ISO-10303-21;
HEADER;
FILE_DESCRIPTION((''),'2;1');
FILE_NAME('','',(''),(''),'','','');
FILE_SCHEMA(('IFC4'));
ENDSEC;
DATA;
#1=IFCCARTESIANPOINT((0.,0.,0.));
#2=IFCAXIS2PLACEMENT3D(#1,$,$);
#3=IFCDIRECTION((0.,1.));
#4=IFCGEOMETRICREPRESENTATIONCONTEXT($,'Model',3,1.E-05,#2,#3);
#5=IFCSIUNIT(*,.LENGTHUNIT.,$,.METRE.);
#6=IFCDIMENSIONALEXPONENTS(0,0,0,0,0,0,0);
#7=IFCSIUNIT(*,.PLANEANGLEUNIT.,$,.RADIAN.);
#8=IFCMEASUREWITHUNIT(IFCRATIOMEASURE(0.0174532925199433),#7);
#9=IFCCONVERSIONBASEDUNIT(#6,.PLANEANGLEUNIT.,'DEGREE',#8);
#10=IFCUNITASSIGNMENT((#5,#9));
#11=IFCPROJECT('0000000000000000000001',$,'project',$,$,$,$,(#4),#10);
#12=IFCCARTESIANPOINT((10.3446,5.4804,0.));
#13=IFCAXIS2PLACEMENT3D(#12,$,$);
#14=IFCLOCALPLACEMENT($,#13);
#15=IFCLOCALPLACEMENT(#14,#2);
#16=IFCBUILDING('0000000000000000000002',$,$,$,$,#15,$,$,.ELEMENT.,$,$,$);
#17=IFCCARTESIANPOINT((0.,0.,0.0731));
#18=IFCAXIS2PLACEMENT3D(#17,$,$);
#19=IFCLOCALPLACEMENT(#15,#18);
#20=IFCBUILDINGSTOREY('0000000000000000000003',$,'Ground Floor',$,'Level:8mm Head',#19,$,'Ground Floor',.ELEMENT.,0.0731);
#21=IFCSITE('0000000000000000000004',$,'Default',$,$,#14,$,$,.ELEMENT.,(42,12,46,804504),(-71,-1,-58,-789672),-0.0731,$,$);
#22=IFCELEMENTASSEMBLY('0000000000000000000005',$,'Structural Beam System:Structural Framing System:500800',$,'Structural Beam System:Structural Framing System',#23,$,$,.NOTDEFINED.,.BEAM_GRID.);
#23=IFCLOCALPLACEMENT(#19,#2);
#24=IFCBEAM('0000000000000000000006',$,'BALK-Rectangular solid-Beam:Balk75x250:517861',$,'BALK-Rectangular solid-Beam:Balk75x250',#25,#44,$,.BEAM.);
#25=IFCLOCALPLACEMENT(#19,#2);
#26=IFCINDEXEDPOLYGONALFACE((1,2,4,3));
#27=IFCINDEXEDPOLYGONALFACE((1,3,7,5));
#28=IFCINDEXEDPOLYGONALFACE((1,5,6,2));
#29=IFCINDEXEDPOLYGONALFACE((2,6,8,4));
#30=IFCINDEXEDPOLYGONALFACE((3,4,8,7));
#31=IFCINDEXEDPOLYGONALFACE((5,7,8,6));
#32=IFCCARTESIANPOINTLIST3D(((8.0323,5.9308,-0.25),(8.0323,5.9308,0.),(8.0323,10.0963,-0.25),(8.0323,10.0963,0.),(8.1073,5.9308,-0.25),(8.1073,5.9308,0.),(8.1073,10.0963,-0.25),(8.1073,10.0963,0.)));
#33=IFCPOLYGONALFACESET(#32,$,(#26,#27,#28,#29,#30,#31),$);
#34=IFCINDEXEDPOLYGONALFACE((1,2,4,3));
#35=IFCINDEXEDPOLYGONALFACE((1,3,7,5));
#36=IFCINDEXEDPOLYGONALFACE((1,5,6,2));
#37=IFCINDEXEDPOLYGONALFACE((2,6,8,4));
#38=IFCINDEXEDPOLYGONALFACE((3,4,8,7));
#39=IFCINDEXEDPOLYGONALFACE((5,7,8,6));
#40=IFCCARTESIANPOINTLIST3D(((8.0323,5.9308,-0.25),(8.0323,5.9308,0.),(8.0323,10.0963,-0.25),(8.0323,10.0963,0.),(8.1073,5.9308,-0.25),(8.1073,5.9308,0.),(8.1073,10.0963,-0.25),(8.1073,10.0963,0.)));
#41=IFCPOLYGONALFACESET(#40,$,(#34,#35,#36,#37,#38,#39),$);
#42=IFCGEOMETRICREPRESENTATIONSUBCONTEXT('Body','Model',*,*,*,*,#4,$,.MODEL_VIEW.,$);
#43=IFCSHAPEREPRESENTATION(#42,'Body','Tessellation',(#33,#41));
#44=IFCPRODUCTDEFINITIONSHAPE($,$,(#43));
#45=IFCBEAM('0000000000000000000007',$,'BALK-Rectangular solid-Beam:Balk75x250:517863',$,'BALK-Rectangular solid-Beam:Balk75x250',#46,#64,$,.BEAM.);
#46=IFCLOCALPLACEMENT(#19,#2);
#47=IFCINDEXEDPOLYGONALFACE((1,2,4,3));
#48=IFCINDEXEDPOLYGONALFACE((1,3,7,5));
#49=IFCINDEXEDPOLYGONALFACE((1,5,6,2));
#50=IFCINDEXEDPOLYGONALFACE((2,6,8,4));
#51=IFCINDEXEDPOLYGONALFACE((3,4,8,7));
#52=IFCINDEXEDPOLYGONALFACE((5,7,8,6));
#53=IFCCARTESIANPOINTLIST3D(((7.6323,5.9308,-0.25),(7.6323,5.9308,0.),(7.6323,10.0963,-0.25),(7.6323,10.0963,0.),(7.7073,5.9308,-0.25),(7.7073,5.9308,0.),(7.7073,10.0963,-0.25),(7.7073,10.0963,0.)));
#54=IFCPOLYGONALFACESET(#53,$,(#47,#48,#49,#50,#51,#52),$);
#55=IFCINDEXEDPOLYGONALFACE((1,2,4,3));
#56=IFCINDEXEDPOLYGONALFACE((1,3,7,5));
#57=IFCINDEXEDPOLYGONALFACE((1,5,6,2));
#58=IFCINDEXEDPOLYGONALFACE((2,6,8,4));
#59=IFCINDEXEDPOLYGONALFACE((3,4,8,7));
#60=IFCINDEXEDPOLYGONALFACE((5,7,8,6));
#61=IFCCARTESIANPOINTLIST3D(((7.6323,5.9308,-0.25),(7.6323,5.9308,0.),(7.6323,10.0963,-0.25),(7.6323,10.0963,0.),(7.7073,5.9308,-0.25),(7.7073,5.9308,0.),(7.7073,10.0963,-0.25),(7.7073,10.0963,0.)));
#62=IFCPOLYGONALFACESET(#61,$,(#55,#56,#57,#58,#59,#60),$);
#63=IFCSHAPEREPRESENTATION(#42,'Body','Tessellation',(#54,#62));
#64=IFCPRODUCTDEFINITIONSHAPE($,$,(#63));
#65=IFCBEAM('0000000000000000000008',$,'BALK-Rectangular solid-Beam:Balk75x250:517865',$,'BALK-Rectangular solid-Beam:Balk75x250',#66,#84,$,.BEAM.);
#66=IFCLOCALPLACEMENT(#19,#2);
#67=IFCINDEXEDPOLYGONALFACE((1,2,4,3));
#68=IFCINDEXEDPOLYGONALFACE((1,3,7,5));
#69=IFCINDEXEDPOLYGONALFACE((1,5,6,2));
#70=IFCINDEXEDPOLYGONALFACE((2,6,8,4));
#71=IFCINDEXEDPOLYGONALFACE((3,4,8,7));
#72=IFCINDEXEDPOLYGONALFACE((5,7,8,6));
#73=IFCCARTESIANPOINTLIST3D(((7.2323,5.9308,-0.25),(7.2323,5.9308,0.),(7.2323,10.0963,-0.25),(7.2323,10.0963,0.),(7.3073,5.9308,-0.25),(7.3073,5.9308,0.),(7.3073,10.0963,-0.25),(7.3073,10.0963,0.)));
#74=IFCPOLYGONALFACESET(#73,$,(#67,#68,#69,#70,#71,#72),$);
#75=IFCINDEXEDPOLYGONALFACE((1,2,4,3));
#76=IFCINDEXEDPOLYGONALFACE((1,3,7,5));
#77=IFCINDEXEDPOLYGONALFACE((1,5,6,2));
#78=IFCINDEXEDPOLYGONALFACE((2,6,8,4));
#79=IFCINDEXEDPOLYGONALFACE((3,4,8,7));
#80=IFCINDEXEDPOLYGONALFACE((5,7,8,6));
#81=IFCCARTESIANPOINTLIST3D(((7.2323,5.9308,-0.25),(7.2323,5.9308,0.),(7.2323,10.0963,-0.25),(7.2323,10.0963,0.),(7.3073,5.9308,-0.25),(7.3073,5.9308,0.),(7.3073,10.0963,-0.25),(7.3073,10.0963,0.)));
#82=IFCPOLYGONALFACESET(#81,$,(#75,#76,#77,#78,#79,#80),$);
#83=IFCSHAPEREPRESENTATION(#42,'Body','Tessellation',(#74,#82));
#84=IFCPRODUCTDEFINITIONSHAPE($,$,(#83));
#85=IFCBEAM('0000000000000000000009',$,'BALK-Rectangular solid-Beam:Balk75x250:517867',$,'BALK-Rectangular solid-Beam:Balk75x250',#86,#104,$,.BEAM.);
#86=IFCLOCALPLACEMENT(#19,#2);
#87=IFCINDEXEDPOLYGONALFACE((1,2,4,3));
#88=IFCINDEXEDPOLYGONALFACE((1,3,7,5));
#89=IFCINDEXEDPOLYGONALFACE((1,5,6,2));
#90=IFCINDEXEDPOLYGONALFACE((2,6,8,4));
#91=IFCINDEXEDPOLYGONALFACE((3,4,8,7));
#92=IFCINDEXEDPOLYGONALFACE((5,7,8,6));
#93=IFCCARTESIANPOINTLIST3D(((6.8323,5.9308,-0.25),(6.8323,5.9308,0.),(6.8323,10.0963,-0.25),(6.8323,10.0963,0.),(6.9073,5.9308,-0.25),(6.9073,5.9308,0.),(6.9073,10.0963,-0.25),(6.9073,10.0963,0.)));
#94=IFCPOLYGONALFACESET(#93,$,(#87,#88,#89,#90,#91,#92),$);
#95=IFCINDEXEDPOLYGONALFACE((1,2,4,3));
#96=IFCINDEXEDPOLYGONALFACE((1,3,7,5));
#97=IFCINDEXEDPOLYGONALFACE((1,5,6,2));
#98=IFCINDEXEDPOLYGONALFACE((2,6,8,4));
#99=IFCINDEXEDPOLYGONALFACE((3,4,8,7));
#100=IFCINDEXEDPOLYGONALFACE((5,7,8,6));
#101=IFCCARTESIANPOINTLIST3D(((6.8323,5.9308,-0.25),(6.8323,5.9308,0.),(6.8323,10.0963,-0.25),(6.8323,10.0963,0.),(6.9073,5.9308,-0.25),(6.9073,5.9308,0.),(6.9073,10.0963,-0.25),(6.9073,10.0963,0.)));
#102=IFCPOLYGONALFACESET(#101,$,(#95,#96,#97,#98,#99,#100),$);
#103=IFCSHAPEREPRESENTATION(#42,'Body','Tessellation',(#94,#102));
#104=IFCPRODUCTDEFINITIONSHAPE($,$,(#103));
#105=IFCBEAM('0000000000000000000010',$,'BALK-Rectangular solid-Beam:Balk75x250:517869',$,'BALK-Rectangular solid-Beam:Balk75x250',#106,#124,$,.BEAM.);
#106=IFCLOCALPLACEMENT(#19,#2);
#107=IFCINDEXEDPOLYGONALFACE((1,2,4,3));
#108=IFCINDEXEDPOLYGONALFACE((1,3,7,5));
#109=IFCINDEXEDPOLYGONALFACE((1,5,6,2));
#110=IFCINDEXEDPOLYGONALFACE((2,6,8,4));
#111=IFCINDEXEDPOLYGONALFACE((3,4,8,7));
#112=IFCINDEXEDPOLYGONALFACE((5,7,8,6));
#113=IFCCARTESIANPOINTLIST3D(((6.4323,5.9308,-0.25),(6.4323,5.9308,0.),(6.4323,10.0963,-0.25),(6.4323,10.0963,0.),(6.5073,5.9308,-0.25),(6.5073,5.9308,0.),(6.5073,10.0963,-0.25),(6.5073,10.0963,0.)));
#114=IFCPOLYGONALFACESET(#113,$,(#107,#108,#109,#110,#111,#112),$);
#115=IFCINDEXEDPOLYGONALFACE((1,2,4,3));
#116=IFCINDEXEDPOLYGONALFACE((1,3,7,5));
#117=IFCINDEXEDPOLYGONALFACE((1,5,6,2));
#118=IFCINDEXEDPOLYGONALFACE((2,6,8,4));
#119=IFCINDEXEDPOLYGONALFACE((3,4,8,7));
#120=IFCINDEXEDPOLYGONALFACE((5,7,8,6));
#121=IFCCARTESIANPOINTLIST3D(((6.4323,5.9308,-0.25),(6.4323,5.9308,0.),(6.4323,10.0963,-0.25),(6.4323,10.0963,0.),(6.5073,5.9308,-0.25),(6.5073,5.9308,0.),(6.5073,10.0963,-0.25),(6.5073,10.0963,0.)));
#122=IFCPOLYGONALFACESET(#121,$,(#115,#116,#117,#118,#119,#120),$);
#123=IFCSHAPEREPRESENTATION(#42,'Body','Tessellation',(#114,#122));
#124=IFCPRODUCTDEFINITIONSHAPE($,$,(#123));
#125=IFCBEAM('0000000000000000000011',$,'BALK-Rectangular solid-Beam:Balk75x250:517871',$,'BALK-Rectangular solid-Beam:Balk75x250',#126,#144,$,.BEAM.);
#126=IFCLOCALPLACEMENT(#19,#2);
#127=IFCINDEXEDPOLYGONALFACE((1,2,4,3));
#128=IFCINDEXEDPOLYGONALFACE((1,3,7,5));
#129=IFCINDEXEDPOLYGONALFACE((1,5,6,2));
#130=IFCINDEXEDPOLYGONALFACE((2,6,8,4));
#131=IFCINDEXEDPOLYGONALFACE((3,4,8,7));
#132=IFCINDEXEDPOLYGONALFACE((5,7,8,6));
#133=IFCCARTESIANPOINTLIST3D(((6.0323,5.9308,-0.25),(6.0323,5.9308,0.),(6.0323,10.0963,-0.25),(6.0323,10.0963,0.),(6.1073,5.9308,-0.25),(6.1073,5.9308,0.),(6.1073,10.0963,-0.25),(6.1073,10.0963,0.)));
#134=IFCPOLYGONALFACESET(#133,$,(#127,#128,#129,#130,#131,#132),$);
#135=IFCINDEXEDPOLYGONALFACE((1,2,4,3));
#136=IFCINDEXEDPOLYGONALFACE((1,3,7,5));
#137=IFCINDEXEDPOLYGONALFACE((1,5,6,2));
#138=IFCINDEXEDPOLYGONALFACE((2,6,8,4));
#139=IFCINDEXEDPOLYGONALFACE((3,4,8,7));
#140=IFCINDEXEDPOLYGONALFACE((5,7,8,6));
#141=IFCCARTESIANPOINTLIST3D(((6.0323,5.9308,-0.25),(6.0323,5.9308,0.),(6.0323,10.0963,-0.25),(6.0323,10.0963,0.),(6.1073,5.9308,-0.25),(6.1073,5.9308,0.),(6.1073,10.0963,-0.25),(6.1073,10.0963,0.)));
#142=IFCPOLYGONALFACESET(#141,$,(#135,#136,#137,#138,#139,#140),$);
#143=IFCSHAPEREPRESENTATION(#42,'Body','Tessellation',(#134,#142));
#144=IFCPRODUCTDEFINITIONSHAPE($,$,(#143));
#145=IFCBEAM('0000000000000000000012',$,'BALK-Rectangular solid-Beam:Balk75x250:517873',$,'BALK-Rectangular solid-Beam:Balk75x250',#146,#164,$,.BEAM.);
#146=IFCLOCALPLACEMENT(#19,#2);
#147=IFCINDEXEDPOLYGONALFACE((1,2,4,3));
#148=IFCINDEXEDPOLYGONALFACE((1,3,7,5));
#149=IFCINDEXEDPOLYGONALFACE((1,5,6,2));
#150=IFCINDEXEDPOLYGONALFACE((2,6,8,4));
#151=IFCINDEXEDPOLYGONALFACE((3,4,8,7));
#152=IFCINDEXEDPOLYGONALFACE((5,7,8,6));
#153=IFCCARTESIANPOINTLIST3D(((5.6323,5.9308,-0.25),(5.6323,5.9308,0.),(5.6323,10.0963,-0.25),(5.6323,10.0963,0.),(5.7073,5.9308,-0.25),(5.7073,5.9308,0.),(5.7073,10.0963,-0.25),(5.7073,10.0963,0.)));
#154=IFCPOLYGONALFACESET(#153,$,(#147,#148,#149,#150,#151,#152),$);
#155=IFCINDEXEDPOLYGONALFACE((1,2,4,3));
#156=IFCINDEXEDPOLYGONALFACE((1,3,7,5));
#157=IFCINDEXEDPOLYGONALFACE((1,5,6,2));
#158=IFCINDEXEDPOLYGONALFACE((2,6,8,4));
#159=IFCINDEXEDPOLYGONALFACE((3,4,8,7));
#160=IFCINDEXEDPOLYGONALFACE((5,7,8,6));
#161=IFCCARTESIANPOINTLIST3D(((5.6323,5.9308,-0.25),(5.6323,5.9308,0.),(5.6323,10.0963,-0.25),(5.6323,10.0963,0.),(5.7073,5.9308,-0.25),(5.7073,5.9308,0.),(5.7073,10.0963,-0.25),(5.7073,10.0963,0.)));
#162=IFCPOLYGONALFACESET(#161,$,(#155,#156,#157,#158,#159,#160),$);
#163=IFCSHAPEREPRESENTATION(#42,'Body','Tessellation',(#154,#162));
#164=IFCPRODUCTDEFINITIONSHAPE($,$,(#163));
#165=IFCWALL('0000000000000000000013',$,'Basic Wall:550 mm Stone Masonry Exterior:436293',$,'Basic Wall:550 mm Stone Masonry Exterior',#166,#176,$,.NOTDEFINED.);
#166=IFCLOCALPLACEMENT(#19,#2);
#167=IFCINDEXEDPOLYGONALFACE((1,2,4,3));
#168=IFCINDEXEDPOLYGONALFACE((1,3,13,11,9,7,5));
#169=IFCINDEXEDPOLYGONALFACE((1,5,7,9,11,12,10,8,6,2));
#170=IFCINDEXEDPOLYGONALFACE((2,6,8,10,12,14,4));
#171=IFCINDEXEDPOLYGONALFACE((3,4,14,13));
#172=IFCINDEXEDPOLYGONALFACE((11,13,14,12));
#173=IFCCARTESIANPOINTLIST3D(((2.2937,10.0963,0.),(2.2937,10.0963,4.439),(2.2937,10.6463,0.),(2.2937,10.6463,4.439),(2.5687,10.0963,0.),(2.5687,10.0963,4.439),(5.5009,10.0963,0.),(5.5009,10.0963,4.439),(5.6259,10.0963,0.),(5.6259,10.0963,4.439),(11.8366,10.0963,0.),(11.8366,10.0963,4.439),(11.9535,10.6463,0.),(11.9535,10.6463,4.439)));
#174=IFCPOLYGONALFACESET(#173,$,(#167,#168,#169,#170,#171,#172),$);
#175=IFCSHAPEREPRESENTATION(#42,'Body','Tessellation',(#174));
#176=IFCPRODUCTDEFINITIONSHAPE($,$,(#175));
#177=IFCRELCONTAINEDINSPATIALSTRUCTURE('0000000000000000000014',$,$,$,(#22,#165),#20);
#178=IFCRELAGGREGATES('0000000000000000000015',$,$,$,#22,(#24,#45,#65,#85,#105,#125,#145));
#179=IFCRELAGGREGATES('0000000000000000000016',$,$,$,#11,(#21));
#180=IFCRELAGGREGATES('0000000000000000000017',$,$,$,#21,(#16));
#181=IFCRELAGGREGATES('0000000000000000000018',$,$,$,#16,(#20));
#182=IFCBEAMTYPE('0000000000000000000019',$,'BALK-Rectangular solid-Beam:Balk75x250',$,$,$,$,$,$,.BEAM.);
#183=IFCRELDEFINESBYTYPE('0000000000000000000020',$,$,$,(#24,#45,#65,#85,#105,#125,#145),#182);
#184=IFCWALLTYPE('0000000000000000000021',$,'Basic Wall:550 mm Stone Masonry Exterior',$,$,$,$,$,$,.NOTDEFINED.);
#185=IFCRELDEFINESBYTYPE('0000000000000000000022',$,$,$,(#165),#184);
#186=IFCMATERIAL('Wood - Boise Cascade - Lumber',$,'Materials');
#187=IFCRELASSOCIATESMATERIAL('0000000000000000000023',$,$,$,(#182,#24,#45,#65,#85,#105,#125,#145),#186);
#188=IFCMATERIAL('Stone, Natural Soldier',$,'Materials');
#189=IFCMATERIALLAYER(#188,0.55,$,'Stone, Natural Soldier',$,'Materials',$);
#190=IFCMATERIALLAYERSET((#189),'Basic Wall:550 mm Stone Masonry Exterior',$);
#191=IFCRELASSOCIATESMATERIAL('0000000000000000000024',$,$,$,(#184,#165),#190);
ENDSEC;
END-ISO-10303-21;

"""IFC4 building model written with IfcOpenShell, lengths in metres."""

from ifc_helpers import new_model, entity, si_unit, converted_unit, direction, frame, frame_2d, origin, origin_2d_with_axis, place, context, subcontext, project, spatial, polyline, rectangle, outline, extrude, source, transform, mapped, material, layer, layer_set, layer_usage, material_profile, profile_set, profile_usage, type_object, type_shapes, element, aggregate, save


model = new_model("IFC4")

# Units and contexts
model_context = context("Model", 3, precision=1e-05, world=origin(), true_north=direction((0.0, 1.0)))
body_context = subcontext(model_context, "Body", "Model", "MODEL_VIEW")
ifc_project = project(units=[si_unit("LENGTHUNIT", "METRE"), converted_unit("PLANEANGLEUNIT", "DEGREE", entity("IfcRatioMeasure", 0.0174532925199433), si_unit("PLANEANGLEUNIT", "RADIAN"), dimensions=[0, 0, 0, 0, 0, 0, 0])], contexts=[model_context])

# Site, building, storey
site_placement = place(None, frame((10.3446, 5.4804, 0.0)))
site = spatial("IfcSite", under=ifc_project, at=site_placement, Name="Default", CompositionType="ELEMENT", RefLatitude=(42, 12, 46, 804504), RefLongitude=(-71, -1, -58, -789672), RefElevation=-0.0731)
building_placement = place(site_placement, origin())
building = spatial("IfcBuilding", under=site, at=building_placement, CompositionType="ELEMENT")
storey_placement = place(building_placement, frame((0.0, 0.0, 0.0731)))
storey = spatial("IfcBuildingStorey", under=building, at=storey_placement, Name="Ground Floor", ObjectType="Level:8mm Head", LongName="Ground Floor", CompositionType="ELEMENT", Elevation=0.0731)

# Element assembly, beams
ifc_material_1 = material(Name="Wood - Boise Cascade - Lumber", Category="Materials")
ifc_material_profile = material_profile(ifc_material_1, rectangle(XDim=0.25, YDim=0.075, at=frame_2d((0.0, 0.0), x_axis=(1.0, 0.0))), Name="Balk75x250")
ifc_profile_set = profile_set([ifc_material_profile], Name="Balk75x250")
assembly_1_placement = place(storey_placement, origin())
assembly_1 = element("IfcElementAssembly", 1, at=assembly_1_placement, inside=storey, Name="Structural Beam System:Structural Framing System:500800", ObjectType="Structural Beam System:Structural Framing System", AssemblyPlace="NOTDEFINED", PredefinedType="BEAM_GRID")
beam_type_1 = type_object("IfcBeamType", Name="BALK-Rectangular solid-Beam:Balk75x250", PredefinedType="BEAM", material=ifc_profile_set)
shared_shape_1 = source(origin(), body_context, "Body", "SweptSolid", [
    extrude(rectangle(XDim=0.25, YDim=0.075, at=origin_2d_with_axis()), frame((-2.089, 0.0, 0.0), z_axis=(1.0, 0.0, 0.0), x_axis=(0.0, 0.0, -1.0)), (0.0, 0.0, 1.0), 4.1655),
    extrude(rectangle(XDim=0.25, YDim=0.075, at=origin_2d_with_axis()), frame((-2.089, 0.0, 0.0), z_axis=(1.0, 0.0, 0.0), x_axis=(0.0, 0.0, -1.0)), (0.0, 0.0, 1.0), 4.1655),
])
type_shapes(beam_type_1, [shared_shape_1])
ifc_profile_usage_1 = profile_usage(ifc_profile_set, cardinal=8)
beam_1_placement = place(assembly_1_placement, frame((8.0698, 8.0073, -0.125), z_axis=(0.0, 0.0, 1.0), x_axis=(0.0, -1.0, 0.0)))
beam_1 = element("IfcBeam", 2, at=beam_1_placement, type_object=beam_type_1, material=ifc_profile_usage_1, Name="BALK-Rectangular solid-Beam:Balk75x250:517861", ObjectType="BALK-Rectangular solid-Beam:Balk75x250", PredefinedType="BEAM", context=body_context, shape_type="MappedRepresentation", body=[
    mapped(shared_shape_1, transform((0.0, 0.0, 0.0), scale=1.0)),
])
ifc_profile_usage_2 = profile_usage(ifc_profile_set, cardinal=8)
beam_2_placement = place(assembly_1_placement, frame((7.6698, 8.0073, -0.125), z_axis=(0.0, 0.0, 1.0), x_axis=(0.0, -1.0, 0.0)))
beam_2 = element("IfcBeam", 3, at=beam_2_placement, type_object=beam_type_1, material=ifc_profile_usage_2, Name="BALK-Rectangular solid-Beam:Balk75x250:517863", ObjectType="BALK-Rectangular solid-Beam:Balk75x250", PredefinedType="BEAM", context=body_context, shape_type="MappedRepresentation", body=[
    mapped(shared_shape_1, transform((0.0, 0.0, 0.0), scale=1.0)),
])
ifc_profile_usage_3 = profile_usage(ifc_profile_set, cardinal=8)
beam_3_placement = place(assembly_1_placement, frame((7.2698, 8.0073, -0.125), z_axis=(0.0, 0.0, 1.0), x_axis=(0.0, -1.0, 0.0)))
beam_3 = element("IfcBeam", 4, at=beam_3_placement, type_object=beam_type_1, material=ifc_profile_usage_3, Name="BALK-Rectangular solid-Beam:Balk75x250:517865", ObjectType="BALK-Rectangular solid-Beam:Balk75x250", PredefinedType="BEAM", context=body_context, shape_type="MappedRepresentation", body=[
    mapped(shared_shape_1, transform((0.0, 0.0, 0.0), scale=1.0)),
])
ifc_profile_usage_4 = profile_usage(ifc_profile_set, cardinal=8)
beam_4_placement = place(assembly_1_placement, frame((6.8698, 8.0073, -0.125), z_axis=(0.0, 0.0, 1.0), x_axis=(0.0, -1.0, 0.0)))
beam_4 = element("IfcBeam", 5, at=beam_4_placement, type_object=beam_type_1, material=ifc_profile_usage_4, Name="BALK-Rectangular solid-Beam:Balk75x250:517867", ObjectType="BALK-Rectangular solid-Beam:Balk75x250", PredefinedType="BEAM", context=body_context, shape_type="MappedRepresentation", body=[
    mapped(shared_shape_1, transform((0.0, 0.0, 0.0), scale=1.0)),
])
ifc_profile_usage_5 = profile_usage(ifc_profile_set, cardinal=8)
beam_5_placement = place(assembly_1_placement, frame((6.4698, 8.0073, -0.125), z_axis=(0.0, 0.0, 1.0), x_axis=(0.0, -1.0, 0.0)))
beam_5 = element("IfcBeam", 6, at=beam_5_placement, type_object=beam_type_1, material=ifc_profile_usage_5, Name="BALK-Rectangular solid-Beam:Balk75x250:517869", ObjectType="BALK-Rectangular solid-Beam:Balk75x250", PredefinedType="BEAM", context=body_context, shape_type="MappedRepresentation", body=[
    mapped(shared_shape_1, transform((0.0, 0.0, 0.0), scale=1.0)),
])
ifc_profile_usage_6 = profile_usage(ifc_profile_set, cardinal=8)
beam_6_placement = place(assembly_1_placement, frame((6.0698, 8.0073, -0.125), z_axis=(0.0, 0.0, 1.0), x_axis=(0.0, -1.0, 0.0)))
beam_6 = element("IfcBeam", 7, at=beam_6_placement, type_object=beam_type_1, material=ifc_profile_usage_6, Name="BALK-Rectangular solid-Beam:Balk75x250:517871", ObjectType="BALK-Rectangular solid-Beam:Balk75x250", PredefinedType="BEAM", context=body_context, shape_type="MappedRepresentation", body=[
    mapped(shared_shape_1, transform((0.0, 0.0, 0.0), scale=1.0)),
])
ifc_profile_usage_7 = profile_usage(ifc_profile_set, cardinal=8)
beam_7_placement = place(assembly_1_placement, frame((5.6698, 8.0073, -0.125), z_axis=(0.0, 0.0, 1.0), x_axis=(0.0, -1.0, 0.0)))
beam_7 = element("IfcBeam", 8, at=beam_7_placement, type_object=beam_type_1, material=ifc_profile_usage_7, Name="BALK-Rectangular solid-Beam:Balk75x250:517873", ObjectType="BALK-Rectangular solid-Beam:Balk75x250", PredefinedType="BEAM", context=body_context, shape_type="MappedRepresentation", body=[
    mapped(shared_shape_1, transform((0.0, 0.0, 0.0), scale=1.0)),
])
aggregate(assembly_1, [beam_1, beam_2, beam_3, beam_4, beam_5, beam_6, beam_7])

# Wall
ifc_material_2 = material(Name="Stone, Natural Soldier", Category="Materials")
ifc_layer_1 = layer(ifc_material_2, 0.55, Name="Stone, Natural Soldier", Category="Materials")
ifc_layer_set_1 = layer_set([ifc_layer_1], Name="Basic Wall:550 mm Stone Masonry Exterior")
ifc_layer_usage_1 = layer_usage(ifc_layer_set_1, "AXIS2", "NEGATIVE", 0.275)
wall_type_1 = type_object("IfcWallType", Name="Basic Wall:550 mm Stone Masonry Exterior", PredefinedType="NOTDEFINED", material=ifc_layer_set_1)
wall_1_placement = place(storey_placement, frame((11.9535, 10.3713, 0.0), z_axis=(0.0, 0.0, 1.0), x_axis=(-1.0, 0.0, 0.0)))
element("IfcWall", 9, at=wall_1_placement, inside=storey, type_object=wall_type_1, material=ifc_layer_usage_1, Name="Basic Wall:550 mm Stone Masonry Exterior:436293", ObjectType="Basic Wall:550 mm Stone Masonry Exterior", PredefinedType="NOTDEFINED", context=body_context, shape_type="SweptSolid", body=[
    extrude(outline(polyline([(9.6599, -0.275), (9.6599, 0.275), (9.3849, 0.275), (6.4526, 0.275), (6.3276, 0.275), (0.1169, 0.275), (0.0, -0.275), (9.6599, -0.275)])), origin(), (0.0, 0.0, 1.0), 4.439),
])

save(model, "model.ifc")
